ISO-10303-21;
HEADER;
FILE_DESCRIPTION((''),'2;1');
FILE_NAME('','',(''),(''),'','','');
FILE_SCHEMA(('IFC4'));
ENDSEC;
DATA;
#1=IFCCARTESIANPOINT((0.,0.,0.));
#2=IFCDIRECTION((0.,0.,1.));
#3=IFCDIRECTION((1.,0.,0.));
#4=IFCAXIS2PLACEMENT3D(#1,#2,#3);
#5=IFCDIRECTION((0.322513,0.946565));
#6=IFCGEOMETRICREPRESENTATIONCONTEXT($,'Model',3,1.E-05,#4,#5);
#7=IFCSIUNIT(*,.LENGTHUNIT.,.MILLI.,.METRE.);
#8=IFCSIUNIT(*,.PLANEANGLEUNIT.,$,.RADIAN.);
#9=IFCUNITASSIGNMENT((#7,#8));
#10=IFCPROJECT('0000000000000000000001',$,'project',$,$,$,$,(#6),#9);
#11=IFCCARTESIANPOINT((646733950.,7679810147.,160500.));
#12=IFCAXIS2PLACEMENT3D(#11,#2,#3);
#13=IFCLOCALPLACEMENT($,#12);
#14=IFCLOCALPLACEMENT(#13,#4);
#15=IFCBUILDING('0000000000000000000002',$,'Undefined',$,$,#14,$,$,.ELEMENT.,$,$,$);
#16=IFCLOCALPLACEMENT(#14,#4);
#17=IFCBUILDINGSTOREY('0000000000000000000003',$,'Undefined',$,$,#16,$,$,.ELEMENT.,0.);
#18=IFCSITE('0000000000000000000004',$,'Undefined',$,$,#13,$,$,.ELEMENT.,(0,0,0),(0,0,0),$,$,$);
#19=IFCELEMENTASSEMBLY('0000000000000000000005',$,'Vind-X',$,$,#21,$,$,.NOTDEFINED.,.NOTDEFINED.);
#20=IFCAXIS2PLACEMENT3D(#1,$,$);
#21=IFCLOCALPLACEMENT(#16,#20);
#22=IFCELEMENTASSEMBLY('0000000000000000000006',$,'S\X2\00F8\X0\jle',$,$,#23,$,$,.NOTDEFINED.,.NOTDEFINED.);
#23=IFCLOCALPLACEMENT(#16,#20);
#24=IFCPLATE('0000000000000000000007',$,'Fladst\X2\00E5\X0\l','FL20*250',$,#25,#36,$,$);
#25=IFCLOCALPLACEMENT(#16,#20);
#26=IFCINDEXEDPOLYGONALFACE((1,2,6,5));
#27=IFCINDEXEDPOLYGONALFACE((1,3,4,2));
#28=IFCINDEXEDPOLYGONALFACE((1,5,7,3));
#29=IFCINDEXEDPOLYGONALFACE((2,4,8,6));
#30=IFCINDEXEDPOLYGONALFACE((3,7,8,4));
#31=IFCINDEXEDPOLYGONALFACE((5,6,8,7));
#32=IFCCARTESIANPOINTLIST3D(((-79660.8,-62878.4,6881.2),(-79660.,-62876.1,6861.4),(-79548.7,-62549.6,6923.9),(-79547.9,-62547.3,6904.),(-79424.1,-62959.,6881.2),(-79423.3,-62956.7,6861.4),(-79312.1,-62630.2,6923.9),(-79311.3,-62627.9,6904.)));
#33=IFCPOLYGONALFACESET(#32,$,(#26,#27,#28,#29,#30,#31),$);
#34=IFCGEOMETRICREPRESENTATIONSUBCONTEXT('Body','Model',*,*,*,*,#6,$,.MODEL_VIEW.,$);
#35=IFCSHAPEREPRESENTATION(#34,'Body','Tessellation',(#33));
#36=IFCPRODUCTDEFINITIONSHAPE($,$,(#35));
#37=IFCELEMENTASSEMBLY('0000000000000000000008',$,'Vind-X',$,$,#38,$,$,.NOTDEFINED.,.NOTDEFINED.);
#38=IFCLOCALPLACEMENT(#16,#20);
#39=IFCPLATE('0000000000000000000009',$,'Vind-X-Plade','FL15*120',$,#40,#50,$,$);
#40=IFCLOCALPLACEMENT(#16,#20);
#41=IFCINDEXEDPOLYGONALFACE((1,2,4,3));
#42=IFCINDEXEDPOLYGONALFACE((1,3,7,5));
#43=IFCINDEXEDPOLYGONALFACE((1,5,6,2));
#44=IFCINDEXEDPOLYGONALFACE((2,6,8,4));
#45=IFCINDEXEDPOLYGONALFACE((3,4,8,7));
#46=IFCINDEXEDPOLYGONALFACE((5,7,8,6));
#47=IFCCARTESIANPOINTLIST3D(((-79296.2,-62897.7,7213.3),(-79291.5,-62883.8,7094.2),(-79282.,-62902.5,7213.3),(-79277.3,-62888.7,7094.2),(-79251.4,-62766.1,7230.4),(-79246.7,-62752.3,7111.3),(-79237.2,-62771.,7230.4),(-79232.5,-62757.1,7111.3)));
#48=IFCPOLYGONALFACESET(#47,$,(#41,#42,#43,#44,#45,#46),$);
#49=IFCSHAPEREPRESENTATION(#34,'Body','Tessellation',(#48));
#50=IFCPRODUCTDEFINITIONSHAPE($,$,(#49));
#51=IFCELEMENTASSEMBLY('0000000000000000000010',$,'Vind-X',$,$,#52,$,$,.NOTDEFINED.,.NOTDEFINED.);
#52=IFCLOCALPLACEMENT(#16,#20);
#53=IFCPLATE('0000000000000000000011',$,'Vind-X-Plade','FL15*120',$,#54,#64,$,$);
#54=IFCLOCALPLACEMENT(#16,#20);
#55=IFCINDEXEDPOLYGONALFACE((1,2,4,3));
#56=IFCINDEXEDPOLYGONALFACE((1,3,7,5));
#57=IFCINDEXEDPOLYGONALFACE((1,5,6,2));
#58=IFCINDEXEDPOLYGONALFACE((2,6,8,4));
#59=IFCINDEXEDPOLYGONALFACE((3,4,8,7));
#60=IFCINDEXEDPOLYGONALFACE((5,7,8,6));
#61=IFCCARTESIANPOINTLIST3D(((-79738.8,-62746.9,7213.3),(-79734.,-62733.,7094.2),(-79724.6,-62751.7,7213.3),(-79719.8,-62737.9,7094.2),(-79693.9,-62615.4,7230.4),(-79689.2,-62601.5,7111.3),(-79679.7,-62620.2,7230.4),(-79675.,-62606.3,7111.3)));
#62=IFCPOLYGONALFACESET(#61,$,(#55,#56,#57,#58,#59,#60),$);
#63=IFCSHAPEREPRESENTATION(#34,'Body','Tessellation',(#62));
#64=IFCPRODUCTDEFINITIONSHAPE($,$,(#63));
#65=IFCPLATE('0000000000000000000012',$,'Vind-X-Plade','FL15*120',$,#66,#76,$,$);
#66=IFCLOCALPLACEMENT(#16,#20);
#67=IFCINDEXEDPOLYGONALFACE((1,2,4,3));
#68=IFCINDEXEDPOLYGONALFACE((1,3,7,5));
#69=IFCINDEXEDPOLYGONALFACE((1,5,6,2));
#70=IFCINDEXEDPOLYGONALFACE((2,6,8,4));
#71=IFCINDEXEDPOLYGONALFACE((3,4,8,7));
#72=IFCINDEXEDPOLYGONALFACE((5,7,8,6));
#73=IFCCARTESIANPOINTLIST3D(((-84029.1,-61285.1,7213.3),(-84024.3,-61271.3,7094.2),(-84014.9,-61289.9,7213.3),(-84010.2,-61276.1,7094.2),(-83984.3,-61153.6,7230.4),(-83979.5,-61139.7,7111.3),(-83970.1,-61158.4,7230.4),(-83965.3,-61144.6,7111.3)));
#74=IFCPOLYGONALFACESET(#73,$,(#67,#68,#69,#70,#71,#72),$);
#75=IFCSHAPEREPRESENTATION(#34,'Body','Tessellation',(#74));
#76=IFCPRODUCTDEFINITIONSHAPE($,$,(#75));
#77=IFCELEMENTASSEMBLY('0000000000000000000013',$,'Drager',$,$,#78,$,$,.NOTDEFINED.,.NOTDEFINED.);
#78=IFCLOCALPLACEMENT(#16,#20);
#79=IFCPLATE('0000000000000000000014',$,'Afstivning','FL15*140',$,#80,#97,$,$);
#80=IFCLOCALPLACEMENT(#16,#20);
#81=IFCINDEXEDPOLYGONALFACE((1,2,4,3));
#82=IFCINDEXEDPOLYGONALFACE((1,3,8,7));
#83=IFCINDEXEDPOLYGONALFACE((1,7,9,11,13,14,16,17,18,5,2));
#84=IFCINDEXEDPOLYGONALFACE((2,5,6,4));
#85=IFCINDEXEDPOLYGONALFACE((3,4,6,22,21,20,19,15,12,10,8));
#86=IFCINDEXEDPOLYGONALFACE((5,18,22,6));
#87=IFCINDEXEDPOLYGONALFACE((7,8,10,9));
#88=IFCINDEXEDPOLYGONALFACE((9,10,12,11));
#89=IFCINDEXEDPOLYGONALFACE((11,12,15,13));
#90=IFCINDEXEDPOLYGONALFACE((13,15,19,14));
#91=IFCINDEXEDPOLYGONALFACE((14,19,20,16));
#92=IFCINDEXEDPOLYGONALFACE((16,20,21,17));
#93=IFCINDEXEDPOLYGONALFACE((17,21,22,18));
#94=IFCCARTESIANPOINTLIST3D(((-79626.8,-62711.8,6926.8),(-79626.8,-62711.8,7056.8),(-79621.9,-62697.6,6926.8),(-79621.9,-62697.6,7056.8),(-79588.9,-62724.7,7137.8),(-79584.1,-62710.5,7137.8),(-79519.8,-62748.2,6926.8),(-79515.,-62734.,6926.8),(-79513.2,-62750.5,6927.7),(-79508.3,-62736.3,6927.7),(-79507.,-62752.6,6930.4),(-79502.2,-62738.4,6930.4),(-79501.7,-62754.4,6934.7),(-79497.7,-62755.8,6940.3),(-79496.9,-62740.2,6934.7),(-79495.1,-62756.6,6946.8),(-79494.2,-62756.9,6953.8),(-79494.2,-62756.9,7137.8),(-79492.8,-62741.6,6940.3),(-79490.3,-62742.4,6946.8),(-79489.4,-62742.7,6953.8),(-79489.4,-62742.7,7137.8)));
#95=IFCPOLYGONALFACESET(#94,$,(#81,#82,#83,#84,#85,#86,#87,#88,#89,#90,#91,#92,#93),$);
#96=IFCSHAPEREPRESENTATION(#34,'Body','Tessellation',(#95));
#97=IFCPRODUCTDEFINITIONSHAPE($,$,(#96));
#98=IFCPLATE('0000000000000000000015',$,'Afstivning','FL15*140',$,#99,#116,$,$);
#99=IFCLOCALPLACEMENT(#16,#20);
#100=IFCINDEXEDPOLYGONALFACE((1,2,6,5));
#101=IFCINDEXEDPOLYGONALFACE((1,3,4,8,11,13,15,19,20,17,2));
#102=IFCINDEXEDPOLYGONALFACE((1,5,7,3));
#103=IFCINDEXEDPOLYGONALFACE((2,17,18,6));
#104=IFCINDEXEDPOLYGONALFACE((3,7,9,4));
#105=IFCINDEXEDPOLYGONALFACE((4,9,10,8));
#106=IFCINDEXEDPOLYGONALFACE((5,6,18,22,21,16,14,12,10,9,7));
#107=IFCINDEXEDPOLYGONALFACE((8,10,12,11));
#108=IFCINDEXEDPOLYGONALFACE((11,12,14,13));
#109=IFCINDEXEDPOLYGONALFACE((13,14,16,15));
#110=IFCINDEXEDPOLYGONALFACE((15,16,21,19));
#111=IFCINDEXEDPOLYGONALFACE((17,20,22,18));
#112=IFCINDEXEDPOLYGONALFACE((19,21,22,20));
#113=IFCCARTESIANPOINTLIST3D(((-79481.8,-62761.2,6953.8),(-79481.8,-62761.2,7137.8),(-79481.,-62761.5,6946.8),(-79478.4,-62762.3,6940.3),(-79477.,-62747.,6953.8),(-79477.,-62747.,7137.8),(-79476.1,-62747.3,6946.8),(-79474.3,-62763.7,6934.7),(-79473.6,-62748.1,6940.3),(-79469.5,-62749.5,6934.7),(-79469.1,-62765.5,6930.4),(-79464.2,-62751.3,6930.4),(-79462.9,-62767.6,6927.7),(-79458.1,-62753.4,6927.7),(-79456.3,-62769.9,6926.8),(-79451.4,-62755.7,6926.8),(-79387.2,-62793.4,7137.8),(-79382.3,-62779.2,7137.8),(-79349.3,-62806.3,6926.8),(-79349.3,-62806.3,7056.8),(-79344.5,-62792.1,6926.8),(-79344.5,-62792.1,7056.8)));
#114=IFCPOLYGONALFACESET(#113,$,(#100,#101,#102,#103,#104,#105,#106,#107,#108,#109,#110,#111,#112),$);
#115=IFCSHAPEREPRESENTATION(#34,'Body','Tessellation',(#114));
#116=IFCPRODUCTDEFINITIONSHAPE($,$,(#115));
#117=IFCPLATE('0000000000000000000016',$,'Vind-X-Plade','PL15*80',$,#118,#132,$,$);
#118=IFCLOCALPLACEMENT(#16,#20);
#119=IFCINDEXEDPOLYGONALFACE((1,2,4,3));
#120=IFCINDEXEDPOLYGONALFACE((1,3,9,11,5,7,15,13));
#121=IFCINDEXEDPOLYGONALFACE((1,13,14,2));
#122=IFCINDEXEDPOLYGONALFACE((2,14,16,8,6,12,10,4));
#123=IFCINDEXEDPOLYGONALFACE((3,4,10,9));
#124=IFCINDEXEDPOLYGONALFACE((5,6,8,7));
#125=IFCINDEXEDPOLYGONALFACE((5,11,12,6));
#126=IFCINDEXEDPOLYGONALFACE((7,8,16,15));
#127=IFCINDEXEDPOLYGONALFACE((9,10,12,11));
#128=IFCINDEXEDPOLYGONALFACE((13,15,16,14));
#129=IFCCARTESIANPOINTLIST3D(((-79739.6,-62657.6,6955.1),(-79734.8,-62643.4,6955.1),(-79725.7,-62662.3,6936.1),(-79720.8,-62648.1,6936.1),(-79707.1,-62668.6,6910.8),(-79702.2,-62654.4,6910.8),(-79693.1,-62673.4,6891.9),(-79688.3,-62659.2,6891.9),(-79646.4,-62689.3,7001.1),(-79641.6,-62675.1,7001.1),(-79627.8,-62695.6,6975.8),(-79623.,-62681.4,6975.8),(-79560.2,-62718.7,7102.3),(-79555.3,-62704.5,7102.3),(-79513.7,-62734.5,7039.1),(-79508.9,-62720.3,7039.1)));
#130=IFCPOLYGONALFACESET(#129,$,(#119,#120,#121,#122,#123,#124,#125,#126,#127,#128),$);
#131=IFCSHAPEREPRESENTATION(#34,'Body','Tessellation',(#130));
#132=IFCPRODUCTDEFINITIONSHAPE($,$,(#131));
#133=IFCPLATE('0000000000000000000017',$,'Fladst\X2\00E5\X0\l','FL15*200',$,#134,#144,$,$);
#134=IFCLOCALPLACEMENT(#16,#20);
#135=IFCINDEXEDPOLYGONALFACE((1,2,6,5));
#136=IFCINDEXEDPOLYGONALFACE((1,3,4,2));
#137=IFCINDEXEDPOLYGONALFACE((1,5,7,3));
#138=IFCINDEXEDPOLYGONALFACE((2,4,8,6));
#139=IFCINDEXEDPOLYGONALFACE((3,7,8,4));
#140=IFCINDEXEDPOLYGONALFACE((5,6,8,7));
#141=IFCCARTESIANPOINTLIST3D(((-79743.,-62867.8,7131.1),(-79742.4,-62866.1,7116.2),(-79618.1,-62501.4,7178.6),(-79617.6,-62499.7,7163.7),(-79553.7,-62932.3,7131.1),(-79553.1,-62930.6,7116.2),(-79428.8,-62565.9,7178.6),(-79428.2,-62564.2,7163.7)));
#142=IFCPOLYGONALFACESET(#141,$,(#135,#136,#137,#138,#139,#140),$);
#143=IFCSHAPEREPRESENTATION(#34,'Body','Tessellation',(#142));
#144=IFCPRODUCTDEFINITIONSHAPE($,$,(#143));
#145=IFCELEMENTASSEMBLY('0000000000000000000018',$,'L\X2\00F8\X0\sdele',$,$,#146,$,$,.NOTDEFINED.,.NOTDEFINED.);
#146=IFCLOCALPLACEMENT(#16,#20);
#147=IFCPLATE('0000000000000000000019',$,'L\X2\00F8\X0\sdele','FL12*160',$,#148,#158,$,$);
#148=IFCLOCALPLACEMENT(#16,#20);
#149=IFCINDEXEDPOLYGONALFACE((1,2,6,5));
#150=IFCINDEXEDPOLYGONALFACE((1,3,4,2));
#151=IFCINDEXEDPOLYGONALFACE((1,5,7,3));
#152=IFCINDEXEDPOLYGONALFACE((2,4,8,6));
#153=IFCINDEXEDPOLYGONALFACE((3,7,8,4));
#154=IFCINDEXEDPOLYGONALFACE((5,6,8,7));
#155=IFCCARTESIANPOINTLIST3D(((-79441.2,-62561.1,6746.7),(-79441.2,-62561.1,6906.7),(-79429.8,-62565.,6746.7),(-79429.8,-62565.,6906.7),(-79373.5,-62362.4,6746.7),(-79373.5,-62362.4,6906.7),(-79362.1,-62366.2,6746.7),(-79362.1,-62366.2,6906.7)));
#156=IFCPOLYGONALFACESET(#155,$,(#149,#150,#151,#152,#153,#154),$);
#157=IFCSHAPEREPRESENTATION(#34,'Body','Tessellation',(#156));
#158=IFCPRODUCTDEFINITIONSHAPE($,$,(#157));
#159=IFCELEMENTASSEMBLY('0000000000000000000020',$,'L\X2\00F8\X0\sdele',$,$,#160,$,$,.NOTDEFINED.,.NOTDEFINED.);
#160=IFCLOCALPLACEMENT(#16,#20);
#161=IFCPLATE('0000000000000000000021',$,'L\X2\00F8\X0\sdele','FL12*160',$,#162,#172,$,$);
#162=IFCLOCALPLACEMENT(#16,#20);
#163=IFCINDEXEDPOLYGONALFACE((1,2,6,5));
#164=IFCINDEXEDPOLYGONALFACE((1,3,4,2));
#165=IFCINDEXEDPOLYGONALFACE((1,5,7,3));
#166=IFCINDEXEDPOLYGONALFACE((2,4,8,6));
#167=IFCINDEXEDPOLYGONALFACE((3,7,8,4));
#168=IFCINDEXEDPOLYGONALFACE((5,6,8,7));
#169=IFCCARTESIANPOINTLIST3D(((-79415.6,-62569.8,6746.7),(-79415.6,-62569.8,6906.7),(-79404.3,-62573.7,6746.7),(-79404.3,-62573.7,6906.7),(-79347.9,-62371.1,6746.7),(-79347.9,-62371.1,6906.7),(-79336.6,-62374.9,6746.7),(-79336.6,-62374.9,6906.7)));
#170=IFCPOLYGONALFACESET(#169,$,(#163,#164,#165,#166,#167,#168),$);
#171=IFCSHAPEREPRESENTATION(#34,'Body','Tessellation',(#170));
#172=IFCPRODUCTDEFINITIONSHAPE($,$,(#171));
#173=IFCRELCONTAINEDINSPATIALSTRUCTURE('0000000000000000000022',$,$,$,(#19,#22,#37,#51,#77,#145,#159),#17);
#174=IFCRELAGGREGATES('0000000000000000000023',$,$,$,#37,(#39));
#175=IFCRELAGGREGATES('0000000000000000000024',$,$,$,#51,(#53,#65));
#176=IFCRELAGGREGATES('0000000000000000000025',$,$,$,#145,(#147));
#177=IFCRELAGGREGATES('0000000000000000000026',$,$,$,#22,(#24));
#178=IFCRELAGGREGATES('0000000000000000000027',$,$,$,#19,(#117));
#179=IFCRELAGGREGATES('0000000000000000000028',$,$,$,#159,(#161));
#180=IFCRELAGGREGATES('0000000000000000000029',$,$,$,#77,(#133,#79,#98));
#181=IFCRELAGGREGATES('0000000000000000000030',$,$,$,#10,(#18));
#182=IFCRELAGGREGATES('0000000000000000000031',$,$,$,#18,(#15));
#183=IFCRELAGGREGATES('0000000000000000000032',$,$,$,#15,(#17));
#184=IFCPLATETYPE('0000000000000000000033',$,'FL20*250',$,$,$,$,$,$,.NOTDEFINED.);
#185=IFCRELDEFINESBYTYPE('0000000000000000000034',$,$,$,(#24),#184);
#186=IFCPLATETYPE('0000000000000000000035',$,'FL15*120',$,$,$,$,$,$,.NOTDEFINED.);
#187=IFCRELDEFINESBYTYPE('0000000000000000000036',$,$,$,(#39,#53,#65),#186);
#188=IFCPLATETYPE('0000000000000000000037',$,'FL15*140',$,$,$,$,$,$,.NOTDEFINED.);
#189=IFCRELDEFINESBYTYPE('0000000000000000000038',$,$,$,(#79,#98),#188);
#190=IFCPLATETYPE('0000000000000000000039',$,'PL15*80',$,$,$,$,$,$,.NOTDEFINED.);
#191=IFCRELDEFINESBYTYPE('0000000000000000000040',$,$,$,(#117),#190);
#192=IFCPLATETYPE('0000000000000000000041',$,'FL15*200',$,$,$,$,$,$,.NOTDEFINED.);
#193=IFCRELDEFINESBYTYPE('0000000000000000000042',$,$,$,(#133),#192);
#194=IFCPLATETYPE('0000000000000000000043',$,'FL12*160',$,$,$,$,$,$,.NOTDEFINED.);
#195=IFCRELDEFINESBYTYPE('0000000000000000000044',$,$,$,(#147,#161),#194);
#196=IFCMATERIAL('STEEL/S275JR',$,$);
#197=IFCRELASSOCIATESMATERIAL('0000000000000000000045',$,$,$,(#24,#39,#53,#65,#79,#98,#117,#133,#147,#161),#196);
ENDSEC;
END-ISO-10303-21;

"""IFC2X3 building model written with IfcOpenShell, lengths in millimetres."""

from ifc_helpers import new_model, si_unit, direction, frame, frame_2d, origin_with_axes, place, context, subcontext, project, spatial, polyline, circle_curve, parameter, trimmed, segment, composite_curve, outline, extrude, boolean, material, type_object, element, aggregate, save


model = new_model("IFC2X3")

# Units and contexts
model_context = context("Model", 3, precision=1e-05, world=origin_with_axes(), true_north=direction((0.322513, 0.946565)))
body_context = subcontext(model_context, "Body", "Model", "MODEL_VIEW")
ifc_project = project(units=[si_unit("LENGTHUNIT", "METRE", prefix="MILLI"), si_unit("PLANEANGLEUNIT", "RADIAN")], contexts=[model_context])

# Site, building, storey
site_placement = place(None, frame((646733950.0, 7679810147.0, 160500.0), z_axis=(0.0, 0.0, 1.0), x_axis=(1.0, 0.0, 0.0)))
site = spatial("IfcSite", under=ifc_project, at=site_placement, Name="Undefined", CompositionType="ELEMENT", RefLatitude=(0, 0, 0), RefLongitude=(0, 0, 0))
building_placement = place(site_placement, origin_with_axes())
building = spatial("IfcBuilding", under=site, at=building_placement, Name="Undefined", CompositionType="ELEMENT")
storey_placement = place(building_placement, origin_with_axes())
storey = spatial("IfcBuildingStorey", under=building, at=storey_placement, Name="Undefined", CompositionType="ELEMENT", Elevation=0.0)

# Element assembly
assembly_1_placement = place(storey_placement, origin_with_axes())
assembly_1 = element("IfcElementAssembly", 1, at=assembly_1_placement, inside=storey, Name="Vind-X", AssemblyPlace="NOTDEFINED", PredefinedType="NOTDEFINED")

# Shared definitions
ifc_material_1 = material(Name="STEEL/S275JR")

# Element assembly, plate
assembly_2_placement = place(storey_placement, origin_with_axes())
assembly_2 = element("IfcElementAssembly", 2, at=assembly_2_placement, inside=storey, Name="Søjle", AssemblyPlace="NOTDEFINED", PredefinedType="NOTDEFINED")
plate_type_1 = type_object("IfcPlateType", Name="FL20*250", PredefinedType="NOTDEFINED")
plate_1_placement = place(assembly_2_placement, frame((-79542.0, -62917.6, 6871.3), z_axis=(0.039304, 0.115357, -0.992546), x_axis=(0.320109, 0.93951, 0.121869)))
plate_1 = element("IfcPlate", 3, at=plate_1_placement, type_object=plate_type_1, material=ifc_material_1, Name="Fladstål", Description="FL20*250", context=body_context, shape_type="SweptSolid", body=[
    extrude(outline(polyline([(0.0, -125.0), (0.0, 125.0), (350.0, 125.0), (350.0, -125.0), (0.0, -125.0)])), frame((0.0, 0.0, -10.0), z_axis=(0.0, 0.0, 1.0), x_axis=(1.0, 0.0, 0.0)), (0.0, 0.0, 1.0), 20.0),
])

# Element assembly, plate
assembly_3_placement = place(storey_placement, origin_with_axes())
assembly_3 = element("IfcElementAssembly", 4, at=assembly_3_placement, inside=storey, Name="Vind-X", AssemblyPlace="NOTDEFINED", PredefinedType="NOTDEFINED")
plate_type_2 = type_object("IfcPlateType", Name="FL15*120", PredefinedType="NOTDEFINED")
plate_2_placement = place(assembly_3_placement, frame((-79239.6, -62754.7, 7111.3), z_axis=(-0.946565, 0.322513, 0.0), x_axis=(-0.320109, -0.93951, -0.121869)))
plate_2 = element("IfcPlate", 5, at=plate_2_placement, type_object=plate_type_2, material=ifc_material_1, Name="Vind-X-Plade", Description="FL15*120", context=body_context, shape_type="SweptSolid", body=[
    extrude(outline(polyline([(0.0, 0.0), (140.0, 0.0), (140.0, 120.0), (0.0, 120.0), (0.0, 0.0)])), frame((0.0, 0.0, -7.5), z_axis=(0.0, 0.0, 1.0), x_axis=(1.0, 0.0, 0.0)), (0.0, 0.0, 1.0), 15.0),
])
aggregate(assembly_3, [plate_2])

# Element assemblies, plates
assembly_4_placement = place(storey_placement, origin_with_axes())
assembly_4 = element("IfcElementAssembly", 6, at=assembly_4_placement, inside=storey, Name="Vind-X", AssemblyPlace="NOTDEFINED", PredefinedType="NOTDEFINED")
plate_3_placement = place(assembly_4_placement, frame((-79726.9, -62735.5, 7094.2), z_axis=(0.946565, -0.322513, 0.0), x_axis=(0.320109, 0.93951, 0.121869)))
plate_3 = element("IfcPlate", 7, at=plate_3_placement, type_object=plate_type_2, material=ifc_material_1, Name="Vind-X-Plade", Description="FL15*120", context=body_context, shape_type="SweptSolid", body=[
    extrude(outline(polyline([(0.0, 0.0), (140.0, 0.0), (140.0, 120.0), (0.0, 120.0), (0.0, 0.0)])), frame((0.0, 0.0, -7.5), z_axis=(0.0, 0.0, 1.0), x_axis=(1.0, 0.0, 0.0)), (0.0, 0.0, 1.0), 15.0),
])
plate_4_placement = place(assembly_4_placement, frame((-83972.4, -61142.1, 7111.3), z_axis=(-0.946565, 0.322513, 0.0), x_axis=(-0.320109, -0.93951, -0.121869)))
plate_4 = element("IfcPlate", 8, at=plate_4_placement, type_object=plate_type_2, material=ifc_material_1, Name="Vind-X-Plade", Description="FL15*120", context=body_context, shape_type="SweptSolid", body=[
    extrude(outline(polyline([(0.0, 0.0), (140.0, 0.0), (140.0, 120.0), (0.0, 120.0), (0.0, 0.0)])), frame((0.0, 0.0, -7.5), z_axis=(0.0, 0.0, 1.0), x_axis=(1.0, 0.0, 0.0)), (0.0, 0.0, 1.0), 15.0),
])
aggregate(assembly_4, [plate_3, plate_4])
assembly_5_placement = place(storey_placement, origin_with_axes())
assembly_5 = element("IfcElementAssembly", 9, at=assembly_5_placement, inside=storey, Name="Drager", AssemblyPlace="NOTDEFINED", PredefinedType="NOTDEFINED")
plate_type_3 = type_object("IfcPlateType", Name="FL15*140", PredefinedType="NOTDEFINED")
plate_5_placement = place(assembly_5_placement, frame((-79624.3, -62704.7, 6926.8), z_axis=(-0.322513, -0.946565, 0.0), x_axis=(0.946565, -0.322513, 0.0)))
plate_5 = element("IfcPlate", 10, at=plate_5_placement, type_object=plate_type_3, material=ifc_material_1, Name="Afstivning", Description="FL15*140", context=body_context, shape_type="SweptSolid", body=[
    extrude(outline(composite_curve([segment(polyline([(0.0, 0.0), (113.0, 0.0)]), True, "CONTINUOUS"), segment(trimmed(circle_curve(frame_2d((113.0, 27.0), x_axis=(0.0, -1.0)), 27.0), [parameter(0.0)], [parameter(1.570796)], True, "PARAMETER"), True, "CONTINUOUS"), segment(polyline([(140.0, 27.0), (140.0, 211.0), (40.0, 211.0), (0.0, 130.0), (0.0, 0.0)]), True, "CONTINUOUS")], self_intersect=True)), frame((0.0, 0.0, -7.5), z_axis=(0.0, 0.0, 1.0), x_axis=(1.0, 0.0, 0.0)), (0.0, 0.0, 1.0), 15.0),
])
plate_6_placement = place(assembly_5_placement, frame((-79479.4, -62754.1, 6926.8), z_axis=(-0.322513, -0.946565, 0.0), x_axis=(0.946565, -0.322513, 0.0)))
plate_6 = element("IfcPlate", 11, at=plate_6_placement, type_object=plate_type_3, material=ifc_material_1, Name="Afstivning", Description="FL15*140", context=body_context, shape_type="SweptSolid", body=[
    extrude(outline(composite_curve([segment(trimmed(circle_curve(frame_2d((27.0, 27.0), x_axis=(-1.0, 0.0)), 27.0), [parameter(0.0)], [parameter(1.570796)], True, "PARAMETER"), True, "CONTINUOUS"), segment(polyline([(27.0, 0.0), (140.0, 0.0), (140.0, 130.0), (100.0, 211.0), (0.0, 211.0), (0.0, 27.0)]), True, "CONTINUOUS")], self_intersect=True)), frame((0.0, 0.0, -7.5), z_axis=(0.0, 0.0, 1.0), x_axis=(1.0, 0.0, 0.0)), (0.0, 0.0, 1.0), 15.0),
])

# Plates
plate_type_4 = type_object("IfcPlateType", Name="PL15*80", PredefinedType="NOTDEFINED")
plate_7_placement = place(assembly_1_placement, frame((-79511.3, -62727.4, 7039.1), z_axis=(-0.322513, -0.946565, 0.0), x_axis=(-0.580575, 0.197813, 0.789812)))
plate_7 = element("IfcPlate", 12, at=plate_7_placement, type_object=plate_type_4, material=ifc_material_1, Name="Vind-X-Plade", Description="PL15*80", context=body_context, shape_type="CSG", body=[
    boolean("DIFFERENCE", extrude(outline(polyline([(0.0, 0.0), (80.0, 0.0), (80.0, 240.0), (0.0, 240.0), (0.0, 0.0)])), frame((0.0, 0.0, -7.5), z_axis=(0.0, 0.0, 1.0), x_axis=(1.0, 0.0, 0.0)), (0.0, 0.0, 1.0), 15.0), extrude(outline(polyline([(0.0, 0.0), (106.0, 0.0), (106.0, 32.0), (0.0, 32.0), (0.0, 0.0)])), frame((56.0, 240.0, 8.5), z_axis=(0.0, 0.0, -1.0), x_axis=(0.0, -1.0, 0.0)), (0.0, 0.0, 1.0), 17.0)),
])
plate_type_5 = type_object("IfcPlateType", Name="FL15*200", PredefinedType="NOTDEFINED")
plate_8_placement = place(assembly_5_placement, frame((-79553.4, -62931.5, 7123.6), z_axis=(-0.039304, -0.115357, 0.992546), x_axis=(0.320109, 0.93951, 0.121869)))
plate_8 = element("IfcPlate", 13, at=plate_8_placement, type_object=plate_type_5, material=ifc_material_1, Name="Fladstål", Description="FL15*200", context=body_context, shape_type="SweptSolid", body=[
    extrude(outline(polyline([(0.0, 0.0), (390.0, 0.0), (390.0, 200.0), (0.0, 200.0), (0.0, 0.0)])), frame((0.0, 0.0, -7.5), z_axis=(0.0, 0.0, 1.0), x_axis=(1.0, 0.0, 0.0)), (0.0, 0.0, 1.0), 15.0),
])

# Element assemblies, plates
assembly_6_placement = place(storey_placement, origin_with_axes())
assembly_6 = element("IfcElementAssembly", 14, at=assembly_6_placement, inside=storey, Name="Løsdele", AssemblyPlace="NOTDEFINED", PredefinedType="NOTDEFINED")
plate_type_6 = type_object("IfcPlateType", Name="FL12*160", PredefinedType="NOTDEFINED")
plate_9_placement = place(assembly_6_placement, frame((-79435.5, -62563.1, 6826.7), z_axis=(-0.946565, 0.322513, 0.0), x_axis=(0.322513, 0.946565, 0.0)))
plate_9 = element("IfcPlate", 15, at=plate_9_placement, type_object=plate_type_6, material=ifc_material_1, Name="Løsdele", Description="FL12*160", context=body_context, shape_type="SweptSolid", body=[
    extrude(outline(polyline([(0.0, -80.0), (0.0, 80.0), (210.0, 80.0), (210.0, -80.0), (0.0, -80.0)])), frame((0.0, 0.0, -6.0), z_axis=(0.0, 0.0, 1.0), x_axis=(1.0, 0.0, 0.0)), (0.0, 0.0, 1.0), 12.0),
])
aggregate(assembly_6, [plate_9])
assembly_7_placement = place(storey_placement, origin_with_axes())
assembly_7 = element("IfcElementAssembly", 16, at=assembly_7_placement, inside=storey, Name="Løsdele", AssemblyPlace="NOTDEFINED", PredefinedType="NOTDEFINED")
plate_10_placement = place(assembly_7_placement, frame((-79410.0, -62571.8, 6826.7), z_axis=(-0.946565, 0.322513, 0.0), x_axis=(0.322513, 0.946565, 0.0)))
plate_10 = element("IfcPlate", 17, at=plate_10_placement, type_object=plate_type_6, material=ifc_material_1, Name="Løsdele", Description="FL12*160", context=body_context, shape_type="SweptSolid", body=[
    extrude(outline(polyline([(0.0, -80.0), (0.0, 80.0), (210.0, 80.0), (210.0, -80.0), (0.0, -80.0)])), frame((0.0, 0.0, -6.0), z_axis=(0.0, 0.0, 1.0), x_axis=(1.0, 0.0, 0.0)), (0.0, 0.0, 1.0), 12.0),
])

aggregate(assembly_2, [plate_1])

aggregate(assembly_1, [plate_7])
aggregate(assembly_7, [plate_10])
aggregate(assembly_5, [plate_8, plate_5, plate_6])

save(model, "model.ifc")
